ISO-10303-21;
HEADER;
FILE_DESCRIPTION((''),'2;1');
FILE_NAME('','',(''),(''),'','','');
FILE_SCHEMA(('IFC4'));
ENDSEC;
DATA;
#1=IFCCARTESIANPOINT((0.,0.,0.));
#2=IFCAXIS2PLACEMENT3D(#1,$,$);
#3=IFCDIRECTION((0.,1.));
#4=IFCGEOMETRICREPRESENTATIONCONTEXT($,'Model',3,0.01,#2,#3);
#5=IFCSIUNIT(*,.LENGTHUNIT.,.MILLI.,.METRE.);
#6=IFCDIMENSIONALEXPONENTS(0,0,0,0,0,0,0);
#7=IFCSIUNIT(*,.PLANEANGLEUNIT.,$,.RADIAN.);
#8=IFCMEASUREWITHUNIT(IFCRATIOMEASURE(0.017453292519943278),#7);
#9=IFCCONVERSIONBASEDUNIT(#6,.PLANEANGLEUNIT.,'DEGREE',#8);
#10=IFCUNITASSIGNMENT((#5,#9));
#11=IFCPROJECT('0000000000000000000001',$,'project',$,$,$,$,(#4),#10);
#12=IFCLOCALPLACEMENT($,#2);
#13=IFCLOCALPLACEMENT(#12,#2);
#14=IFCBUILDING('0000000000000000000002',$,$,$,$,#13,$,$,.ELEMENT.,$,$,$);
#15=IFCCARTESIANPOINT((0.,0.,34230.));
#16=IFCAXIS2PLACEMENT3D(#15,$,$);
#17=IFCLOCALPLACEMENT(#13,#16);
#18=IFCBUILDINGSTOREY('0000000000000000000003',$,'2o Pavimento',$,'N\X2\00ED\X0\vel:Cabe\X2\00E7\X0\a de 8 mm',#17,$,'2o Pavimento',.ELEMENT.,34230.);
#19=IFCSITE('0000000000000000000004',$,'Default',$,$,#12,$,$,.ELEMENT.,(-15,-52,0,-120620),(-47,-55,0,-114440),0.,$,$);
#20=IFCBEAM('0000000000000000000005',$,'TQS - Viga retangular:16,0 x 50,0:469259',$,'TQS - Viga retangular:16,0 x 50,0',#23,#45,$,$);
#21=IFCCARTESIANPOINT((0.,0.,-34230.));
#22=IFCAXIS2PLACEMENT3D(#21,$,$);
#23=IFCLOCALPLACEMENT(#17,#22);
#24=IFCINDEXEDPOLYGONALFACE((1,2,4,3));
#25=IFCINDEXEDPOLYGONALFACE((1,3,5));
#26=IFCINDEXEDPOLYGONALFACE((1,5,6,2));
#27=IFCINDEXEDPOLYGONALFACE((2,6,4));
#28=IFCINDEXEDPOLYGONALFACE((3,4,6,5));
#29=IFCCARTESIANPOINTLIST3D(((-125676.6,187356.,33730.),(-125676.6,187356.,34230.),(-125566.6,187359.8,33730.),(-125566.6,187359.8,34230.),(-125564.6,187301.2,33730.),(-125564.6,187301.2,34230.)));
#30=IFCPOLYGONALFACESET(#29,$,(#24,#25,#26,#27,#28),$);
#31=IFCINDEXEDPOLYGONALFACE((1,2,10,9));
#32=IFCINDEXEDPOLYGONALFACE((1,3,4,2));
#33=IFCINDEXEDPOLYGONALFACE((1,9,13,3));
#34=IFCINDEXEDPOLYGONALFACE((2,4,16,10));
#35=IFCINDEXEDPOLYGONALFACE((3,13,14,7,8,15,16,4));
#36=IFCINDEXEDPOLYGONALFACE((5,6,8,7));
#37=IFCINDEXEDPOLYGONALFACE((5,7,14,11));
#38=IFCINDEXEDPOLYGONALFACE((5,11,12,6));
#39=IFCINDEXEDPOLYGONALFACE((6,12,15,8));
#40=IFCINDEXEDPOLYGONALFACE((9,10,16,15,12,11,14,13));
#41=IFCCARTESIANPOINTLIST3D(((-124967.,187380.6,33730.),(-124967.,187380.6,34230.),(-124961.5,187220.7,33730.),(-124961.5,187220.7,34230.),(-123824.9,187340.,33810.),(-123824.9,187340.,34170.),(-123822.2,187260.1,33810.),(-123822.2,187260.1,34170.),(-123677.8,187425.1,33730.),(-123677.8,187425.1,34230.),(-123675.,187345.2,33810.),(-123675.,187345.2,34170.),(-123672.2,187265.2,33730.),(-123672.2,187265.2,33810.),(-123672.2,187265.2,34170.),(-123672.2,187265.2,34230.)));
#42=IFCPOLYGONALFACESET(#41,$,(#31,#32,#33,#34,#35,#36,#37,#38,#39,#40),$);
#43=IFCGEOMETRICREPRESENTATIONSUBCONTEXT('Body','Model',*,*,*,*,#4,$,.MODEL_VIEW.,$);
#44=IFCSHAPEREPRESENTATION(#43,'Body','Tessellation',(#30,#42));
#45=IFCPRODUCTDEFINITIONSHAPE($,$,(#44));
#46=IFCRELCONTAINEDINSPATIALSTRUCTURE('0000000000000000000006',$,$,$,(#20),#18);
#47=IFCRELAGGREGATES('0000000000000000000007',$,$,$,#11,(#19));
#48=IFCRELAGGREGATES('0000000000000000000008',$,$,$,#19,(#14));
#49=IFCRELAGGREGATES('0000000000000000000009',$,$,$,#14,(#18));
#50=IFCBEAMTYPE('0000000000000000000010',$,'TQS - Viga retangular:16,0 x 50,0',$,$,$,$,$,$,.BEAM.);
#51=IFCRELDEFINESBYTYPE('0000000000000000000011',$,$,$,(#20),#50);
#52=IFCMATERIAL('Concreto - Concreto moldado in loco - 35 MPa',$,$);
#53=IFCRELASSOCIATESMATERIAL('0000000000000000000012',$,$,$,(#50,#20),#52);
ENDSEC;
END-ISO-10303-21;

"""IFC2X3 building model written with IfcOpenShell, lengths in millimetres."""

from ifc_helpers import new_model, entity, si_unit, converted_unit, direction, frame, frame_2d, origin, origin_2d_with_axis, place, context, subcontext, project, spatial, polyline, rectangle, extrude, boolean, clip, halfspace, bounded_halfspace, source, transform, mapped, material, type_object, type_shapes, element, save


model = new_model("IFC2X3")

# Units and contexts
model_context = context("Model", 3, precision=0.01, world=origin(), true_north=direction((0.0, 1.0)))
body_context = subcontext(model_context, "Body", "Model", "MODEL_VIEW")
ifc_project = project(units=[si_unit("LENGTHUNIT", "METRE", prefix="MILLI"), converted_unit("PLANEANGLEUNIT", "DEGREE", entity("IfcRatioMeasure", 0.017453292519943278), si_unit("PLANEANGLEUNIT", "RADIAN"), dimensions=[0, 0, 0, 0, 0, 0, 0])], contexts=[model_context])

# Site, building, storey
site_placement = place(None, origin())
site = spatial("IfcSite", under=ifc_project, at=site_placement, Name="Default", CompositionType="ELEMENT", RefLatitude=(-15, -52, 0, -120620), RefLongitude=(-47, -55, 0, -114440), RefElevation=0.0)
building_placement = place(site_placement, origin())
building = spatial("IfcBuilding", under=site, at=building_placement, CompositionType="ELEMENT")
storey_placement = place(building_placement, frame((0.0, 0.0, 34230.0)))
storey = spatial("IfcBuildingStorey", under=building, at=storey_placement, Name="2o Pavimento", ObjectType="Nível:Cabeça de 8 mm", LongName="2o Pavimento", CompositionType="ELEMENT", Elevation=34230.0)

# Shared definitions
ifc_material = material(Name="Concreto - Concreto moldado in loco - 35 MPa")

# Beam
beam_type_1 = type_object("IfcBeamType", Name="TQS - Viga retangular:16,0 x 50,0", PredefinedType="BEAM", material=ifc_material)
shared_shape_1 = source(origin(), body_context, "Body", "SweptSolid", [
    clip(extrude(rectangle(XDim=500.0, YDim=58.7, at=frame_2d((0.0, 0.0), x_axis=(1.0, 0.0))), frame((-125565.6, 187330.5, 33980.0), z_axis=(-0.999403, -0.034551, 0.0), x_axis=(0.0, 0.0, -1.0)), (0.0, 0.0, 1.0), 110.0), halfspace(frame((-125371.2, 187206.5, 34230.0), z_axis=(-0.439821, -0.898085, 0.0), x_axis=(0.898085, -0.439821, 0.0)), False)),
    boolean("DIFFERENCE", clip(extrude(rectangle(XDim=500.0, YDim=160.0, at=origin_2d_with_axis()), frame((-123675.0, 187345.2, 33980.0), z_axis=(-0.999403, -0.034551, 0.0), x_axis=(0.0, 0.0, -1.0)), (0.0, 0.0, 1.0), 1290.0), bounded_halfspace(frame((-123824.9, 187340.0, 33810.0), z_axis=(0.999403, 0.034551, 0.0), x_axis=(0.034551, -0.999403, 0.0)), False, frame((-123675.0, 187345.2, 33980.0), z_axis=(-0.999403, -0.034551, 0.0), x_axis=(0.0, 0.0, -1.0)), polyline([(170.0, 0.0), (-190.0, 0.0), (-190.0, 80.0), (-90.0, 80.0), (170.0, 80.0), (170.0, 0.0)]))), extrude(rectangle(XDim=360.0, YDim=80.0, at=frame_2d((0.0, 0.0), x_axis=(0.0, 1.0))), frame((-123673.6, 187305.2, 33990.0), z_axis=(0.999403, 0.034551, 0.0), x_axis=(-0.034551, 0.999403, 0.0)), (0.0, 0.0, -1.0), 150.0)),
])
type_shapes(beam_type_1, [shared_shape_1])
beam_1_placement = place(storey_placement, frame((0.0, 0.0, -34230.0)))
element("IfcBeam", 1, at=beam_1_placement, inside=storey, type_object=beam_type_1, material=ifc_material, Name="TQS - Viga retangular:16,0 x 50,0:469259", ObjectType="TQS - Viga retangular:16,0 x 50,0", context=body_context, shape_type="MappedRepresentation", body=[
    mapped(shared_shape_1, transform((0.0, 0.0, 0.0), scale=1.0)),
])

save(model, "model.ifc")
